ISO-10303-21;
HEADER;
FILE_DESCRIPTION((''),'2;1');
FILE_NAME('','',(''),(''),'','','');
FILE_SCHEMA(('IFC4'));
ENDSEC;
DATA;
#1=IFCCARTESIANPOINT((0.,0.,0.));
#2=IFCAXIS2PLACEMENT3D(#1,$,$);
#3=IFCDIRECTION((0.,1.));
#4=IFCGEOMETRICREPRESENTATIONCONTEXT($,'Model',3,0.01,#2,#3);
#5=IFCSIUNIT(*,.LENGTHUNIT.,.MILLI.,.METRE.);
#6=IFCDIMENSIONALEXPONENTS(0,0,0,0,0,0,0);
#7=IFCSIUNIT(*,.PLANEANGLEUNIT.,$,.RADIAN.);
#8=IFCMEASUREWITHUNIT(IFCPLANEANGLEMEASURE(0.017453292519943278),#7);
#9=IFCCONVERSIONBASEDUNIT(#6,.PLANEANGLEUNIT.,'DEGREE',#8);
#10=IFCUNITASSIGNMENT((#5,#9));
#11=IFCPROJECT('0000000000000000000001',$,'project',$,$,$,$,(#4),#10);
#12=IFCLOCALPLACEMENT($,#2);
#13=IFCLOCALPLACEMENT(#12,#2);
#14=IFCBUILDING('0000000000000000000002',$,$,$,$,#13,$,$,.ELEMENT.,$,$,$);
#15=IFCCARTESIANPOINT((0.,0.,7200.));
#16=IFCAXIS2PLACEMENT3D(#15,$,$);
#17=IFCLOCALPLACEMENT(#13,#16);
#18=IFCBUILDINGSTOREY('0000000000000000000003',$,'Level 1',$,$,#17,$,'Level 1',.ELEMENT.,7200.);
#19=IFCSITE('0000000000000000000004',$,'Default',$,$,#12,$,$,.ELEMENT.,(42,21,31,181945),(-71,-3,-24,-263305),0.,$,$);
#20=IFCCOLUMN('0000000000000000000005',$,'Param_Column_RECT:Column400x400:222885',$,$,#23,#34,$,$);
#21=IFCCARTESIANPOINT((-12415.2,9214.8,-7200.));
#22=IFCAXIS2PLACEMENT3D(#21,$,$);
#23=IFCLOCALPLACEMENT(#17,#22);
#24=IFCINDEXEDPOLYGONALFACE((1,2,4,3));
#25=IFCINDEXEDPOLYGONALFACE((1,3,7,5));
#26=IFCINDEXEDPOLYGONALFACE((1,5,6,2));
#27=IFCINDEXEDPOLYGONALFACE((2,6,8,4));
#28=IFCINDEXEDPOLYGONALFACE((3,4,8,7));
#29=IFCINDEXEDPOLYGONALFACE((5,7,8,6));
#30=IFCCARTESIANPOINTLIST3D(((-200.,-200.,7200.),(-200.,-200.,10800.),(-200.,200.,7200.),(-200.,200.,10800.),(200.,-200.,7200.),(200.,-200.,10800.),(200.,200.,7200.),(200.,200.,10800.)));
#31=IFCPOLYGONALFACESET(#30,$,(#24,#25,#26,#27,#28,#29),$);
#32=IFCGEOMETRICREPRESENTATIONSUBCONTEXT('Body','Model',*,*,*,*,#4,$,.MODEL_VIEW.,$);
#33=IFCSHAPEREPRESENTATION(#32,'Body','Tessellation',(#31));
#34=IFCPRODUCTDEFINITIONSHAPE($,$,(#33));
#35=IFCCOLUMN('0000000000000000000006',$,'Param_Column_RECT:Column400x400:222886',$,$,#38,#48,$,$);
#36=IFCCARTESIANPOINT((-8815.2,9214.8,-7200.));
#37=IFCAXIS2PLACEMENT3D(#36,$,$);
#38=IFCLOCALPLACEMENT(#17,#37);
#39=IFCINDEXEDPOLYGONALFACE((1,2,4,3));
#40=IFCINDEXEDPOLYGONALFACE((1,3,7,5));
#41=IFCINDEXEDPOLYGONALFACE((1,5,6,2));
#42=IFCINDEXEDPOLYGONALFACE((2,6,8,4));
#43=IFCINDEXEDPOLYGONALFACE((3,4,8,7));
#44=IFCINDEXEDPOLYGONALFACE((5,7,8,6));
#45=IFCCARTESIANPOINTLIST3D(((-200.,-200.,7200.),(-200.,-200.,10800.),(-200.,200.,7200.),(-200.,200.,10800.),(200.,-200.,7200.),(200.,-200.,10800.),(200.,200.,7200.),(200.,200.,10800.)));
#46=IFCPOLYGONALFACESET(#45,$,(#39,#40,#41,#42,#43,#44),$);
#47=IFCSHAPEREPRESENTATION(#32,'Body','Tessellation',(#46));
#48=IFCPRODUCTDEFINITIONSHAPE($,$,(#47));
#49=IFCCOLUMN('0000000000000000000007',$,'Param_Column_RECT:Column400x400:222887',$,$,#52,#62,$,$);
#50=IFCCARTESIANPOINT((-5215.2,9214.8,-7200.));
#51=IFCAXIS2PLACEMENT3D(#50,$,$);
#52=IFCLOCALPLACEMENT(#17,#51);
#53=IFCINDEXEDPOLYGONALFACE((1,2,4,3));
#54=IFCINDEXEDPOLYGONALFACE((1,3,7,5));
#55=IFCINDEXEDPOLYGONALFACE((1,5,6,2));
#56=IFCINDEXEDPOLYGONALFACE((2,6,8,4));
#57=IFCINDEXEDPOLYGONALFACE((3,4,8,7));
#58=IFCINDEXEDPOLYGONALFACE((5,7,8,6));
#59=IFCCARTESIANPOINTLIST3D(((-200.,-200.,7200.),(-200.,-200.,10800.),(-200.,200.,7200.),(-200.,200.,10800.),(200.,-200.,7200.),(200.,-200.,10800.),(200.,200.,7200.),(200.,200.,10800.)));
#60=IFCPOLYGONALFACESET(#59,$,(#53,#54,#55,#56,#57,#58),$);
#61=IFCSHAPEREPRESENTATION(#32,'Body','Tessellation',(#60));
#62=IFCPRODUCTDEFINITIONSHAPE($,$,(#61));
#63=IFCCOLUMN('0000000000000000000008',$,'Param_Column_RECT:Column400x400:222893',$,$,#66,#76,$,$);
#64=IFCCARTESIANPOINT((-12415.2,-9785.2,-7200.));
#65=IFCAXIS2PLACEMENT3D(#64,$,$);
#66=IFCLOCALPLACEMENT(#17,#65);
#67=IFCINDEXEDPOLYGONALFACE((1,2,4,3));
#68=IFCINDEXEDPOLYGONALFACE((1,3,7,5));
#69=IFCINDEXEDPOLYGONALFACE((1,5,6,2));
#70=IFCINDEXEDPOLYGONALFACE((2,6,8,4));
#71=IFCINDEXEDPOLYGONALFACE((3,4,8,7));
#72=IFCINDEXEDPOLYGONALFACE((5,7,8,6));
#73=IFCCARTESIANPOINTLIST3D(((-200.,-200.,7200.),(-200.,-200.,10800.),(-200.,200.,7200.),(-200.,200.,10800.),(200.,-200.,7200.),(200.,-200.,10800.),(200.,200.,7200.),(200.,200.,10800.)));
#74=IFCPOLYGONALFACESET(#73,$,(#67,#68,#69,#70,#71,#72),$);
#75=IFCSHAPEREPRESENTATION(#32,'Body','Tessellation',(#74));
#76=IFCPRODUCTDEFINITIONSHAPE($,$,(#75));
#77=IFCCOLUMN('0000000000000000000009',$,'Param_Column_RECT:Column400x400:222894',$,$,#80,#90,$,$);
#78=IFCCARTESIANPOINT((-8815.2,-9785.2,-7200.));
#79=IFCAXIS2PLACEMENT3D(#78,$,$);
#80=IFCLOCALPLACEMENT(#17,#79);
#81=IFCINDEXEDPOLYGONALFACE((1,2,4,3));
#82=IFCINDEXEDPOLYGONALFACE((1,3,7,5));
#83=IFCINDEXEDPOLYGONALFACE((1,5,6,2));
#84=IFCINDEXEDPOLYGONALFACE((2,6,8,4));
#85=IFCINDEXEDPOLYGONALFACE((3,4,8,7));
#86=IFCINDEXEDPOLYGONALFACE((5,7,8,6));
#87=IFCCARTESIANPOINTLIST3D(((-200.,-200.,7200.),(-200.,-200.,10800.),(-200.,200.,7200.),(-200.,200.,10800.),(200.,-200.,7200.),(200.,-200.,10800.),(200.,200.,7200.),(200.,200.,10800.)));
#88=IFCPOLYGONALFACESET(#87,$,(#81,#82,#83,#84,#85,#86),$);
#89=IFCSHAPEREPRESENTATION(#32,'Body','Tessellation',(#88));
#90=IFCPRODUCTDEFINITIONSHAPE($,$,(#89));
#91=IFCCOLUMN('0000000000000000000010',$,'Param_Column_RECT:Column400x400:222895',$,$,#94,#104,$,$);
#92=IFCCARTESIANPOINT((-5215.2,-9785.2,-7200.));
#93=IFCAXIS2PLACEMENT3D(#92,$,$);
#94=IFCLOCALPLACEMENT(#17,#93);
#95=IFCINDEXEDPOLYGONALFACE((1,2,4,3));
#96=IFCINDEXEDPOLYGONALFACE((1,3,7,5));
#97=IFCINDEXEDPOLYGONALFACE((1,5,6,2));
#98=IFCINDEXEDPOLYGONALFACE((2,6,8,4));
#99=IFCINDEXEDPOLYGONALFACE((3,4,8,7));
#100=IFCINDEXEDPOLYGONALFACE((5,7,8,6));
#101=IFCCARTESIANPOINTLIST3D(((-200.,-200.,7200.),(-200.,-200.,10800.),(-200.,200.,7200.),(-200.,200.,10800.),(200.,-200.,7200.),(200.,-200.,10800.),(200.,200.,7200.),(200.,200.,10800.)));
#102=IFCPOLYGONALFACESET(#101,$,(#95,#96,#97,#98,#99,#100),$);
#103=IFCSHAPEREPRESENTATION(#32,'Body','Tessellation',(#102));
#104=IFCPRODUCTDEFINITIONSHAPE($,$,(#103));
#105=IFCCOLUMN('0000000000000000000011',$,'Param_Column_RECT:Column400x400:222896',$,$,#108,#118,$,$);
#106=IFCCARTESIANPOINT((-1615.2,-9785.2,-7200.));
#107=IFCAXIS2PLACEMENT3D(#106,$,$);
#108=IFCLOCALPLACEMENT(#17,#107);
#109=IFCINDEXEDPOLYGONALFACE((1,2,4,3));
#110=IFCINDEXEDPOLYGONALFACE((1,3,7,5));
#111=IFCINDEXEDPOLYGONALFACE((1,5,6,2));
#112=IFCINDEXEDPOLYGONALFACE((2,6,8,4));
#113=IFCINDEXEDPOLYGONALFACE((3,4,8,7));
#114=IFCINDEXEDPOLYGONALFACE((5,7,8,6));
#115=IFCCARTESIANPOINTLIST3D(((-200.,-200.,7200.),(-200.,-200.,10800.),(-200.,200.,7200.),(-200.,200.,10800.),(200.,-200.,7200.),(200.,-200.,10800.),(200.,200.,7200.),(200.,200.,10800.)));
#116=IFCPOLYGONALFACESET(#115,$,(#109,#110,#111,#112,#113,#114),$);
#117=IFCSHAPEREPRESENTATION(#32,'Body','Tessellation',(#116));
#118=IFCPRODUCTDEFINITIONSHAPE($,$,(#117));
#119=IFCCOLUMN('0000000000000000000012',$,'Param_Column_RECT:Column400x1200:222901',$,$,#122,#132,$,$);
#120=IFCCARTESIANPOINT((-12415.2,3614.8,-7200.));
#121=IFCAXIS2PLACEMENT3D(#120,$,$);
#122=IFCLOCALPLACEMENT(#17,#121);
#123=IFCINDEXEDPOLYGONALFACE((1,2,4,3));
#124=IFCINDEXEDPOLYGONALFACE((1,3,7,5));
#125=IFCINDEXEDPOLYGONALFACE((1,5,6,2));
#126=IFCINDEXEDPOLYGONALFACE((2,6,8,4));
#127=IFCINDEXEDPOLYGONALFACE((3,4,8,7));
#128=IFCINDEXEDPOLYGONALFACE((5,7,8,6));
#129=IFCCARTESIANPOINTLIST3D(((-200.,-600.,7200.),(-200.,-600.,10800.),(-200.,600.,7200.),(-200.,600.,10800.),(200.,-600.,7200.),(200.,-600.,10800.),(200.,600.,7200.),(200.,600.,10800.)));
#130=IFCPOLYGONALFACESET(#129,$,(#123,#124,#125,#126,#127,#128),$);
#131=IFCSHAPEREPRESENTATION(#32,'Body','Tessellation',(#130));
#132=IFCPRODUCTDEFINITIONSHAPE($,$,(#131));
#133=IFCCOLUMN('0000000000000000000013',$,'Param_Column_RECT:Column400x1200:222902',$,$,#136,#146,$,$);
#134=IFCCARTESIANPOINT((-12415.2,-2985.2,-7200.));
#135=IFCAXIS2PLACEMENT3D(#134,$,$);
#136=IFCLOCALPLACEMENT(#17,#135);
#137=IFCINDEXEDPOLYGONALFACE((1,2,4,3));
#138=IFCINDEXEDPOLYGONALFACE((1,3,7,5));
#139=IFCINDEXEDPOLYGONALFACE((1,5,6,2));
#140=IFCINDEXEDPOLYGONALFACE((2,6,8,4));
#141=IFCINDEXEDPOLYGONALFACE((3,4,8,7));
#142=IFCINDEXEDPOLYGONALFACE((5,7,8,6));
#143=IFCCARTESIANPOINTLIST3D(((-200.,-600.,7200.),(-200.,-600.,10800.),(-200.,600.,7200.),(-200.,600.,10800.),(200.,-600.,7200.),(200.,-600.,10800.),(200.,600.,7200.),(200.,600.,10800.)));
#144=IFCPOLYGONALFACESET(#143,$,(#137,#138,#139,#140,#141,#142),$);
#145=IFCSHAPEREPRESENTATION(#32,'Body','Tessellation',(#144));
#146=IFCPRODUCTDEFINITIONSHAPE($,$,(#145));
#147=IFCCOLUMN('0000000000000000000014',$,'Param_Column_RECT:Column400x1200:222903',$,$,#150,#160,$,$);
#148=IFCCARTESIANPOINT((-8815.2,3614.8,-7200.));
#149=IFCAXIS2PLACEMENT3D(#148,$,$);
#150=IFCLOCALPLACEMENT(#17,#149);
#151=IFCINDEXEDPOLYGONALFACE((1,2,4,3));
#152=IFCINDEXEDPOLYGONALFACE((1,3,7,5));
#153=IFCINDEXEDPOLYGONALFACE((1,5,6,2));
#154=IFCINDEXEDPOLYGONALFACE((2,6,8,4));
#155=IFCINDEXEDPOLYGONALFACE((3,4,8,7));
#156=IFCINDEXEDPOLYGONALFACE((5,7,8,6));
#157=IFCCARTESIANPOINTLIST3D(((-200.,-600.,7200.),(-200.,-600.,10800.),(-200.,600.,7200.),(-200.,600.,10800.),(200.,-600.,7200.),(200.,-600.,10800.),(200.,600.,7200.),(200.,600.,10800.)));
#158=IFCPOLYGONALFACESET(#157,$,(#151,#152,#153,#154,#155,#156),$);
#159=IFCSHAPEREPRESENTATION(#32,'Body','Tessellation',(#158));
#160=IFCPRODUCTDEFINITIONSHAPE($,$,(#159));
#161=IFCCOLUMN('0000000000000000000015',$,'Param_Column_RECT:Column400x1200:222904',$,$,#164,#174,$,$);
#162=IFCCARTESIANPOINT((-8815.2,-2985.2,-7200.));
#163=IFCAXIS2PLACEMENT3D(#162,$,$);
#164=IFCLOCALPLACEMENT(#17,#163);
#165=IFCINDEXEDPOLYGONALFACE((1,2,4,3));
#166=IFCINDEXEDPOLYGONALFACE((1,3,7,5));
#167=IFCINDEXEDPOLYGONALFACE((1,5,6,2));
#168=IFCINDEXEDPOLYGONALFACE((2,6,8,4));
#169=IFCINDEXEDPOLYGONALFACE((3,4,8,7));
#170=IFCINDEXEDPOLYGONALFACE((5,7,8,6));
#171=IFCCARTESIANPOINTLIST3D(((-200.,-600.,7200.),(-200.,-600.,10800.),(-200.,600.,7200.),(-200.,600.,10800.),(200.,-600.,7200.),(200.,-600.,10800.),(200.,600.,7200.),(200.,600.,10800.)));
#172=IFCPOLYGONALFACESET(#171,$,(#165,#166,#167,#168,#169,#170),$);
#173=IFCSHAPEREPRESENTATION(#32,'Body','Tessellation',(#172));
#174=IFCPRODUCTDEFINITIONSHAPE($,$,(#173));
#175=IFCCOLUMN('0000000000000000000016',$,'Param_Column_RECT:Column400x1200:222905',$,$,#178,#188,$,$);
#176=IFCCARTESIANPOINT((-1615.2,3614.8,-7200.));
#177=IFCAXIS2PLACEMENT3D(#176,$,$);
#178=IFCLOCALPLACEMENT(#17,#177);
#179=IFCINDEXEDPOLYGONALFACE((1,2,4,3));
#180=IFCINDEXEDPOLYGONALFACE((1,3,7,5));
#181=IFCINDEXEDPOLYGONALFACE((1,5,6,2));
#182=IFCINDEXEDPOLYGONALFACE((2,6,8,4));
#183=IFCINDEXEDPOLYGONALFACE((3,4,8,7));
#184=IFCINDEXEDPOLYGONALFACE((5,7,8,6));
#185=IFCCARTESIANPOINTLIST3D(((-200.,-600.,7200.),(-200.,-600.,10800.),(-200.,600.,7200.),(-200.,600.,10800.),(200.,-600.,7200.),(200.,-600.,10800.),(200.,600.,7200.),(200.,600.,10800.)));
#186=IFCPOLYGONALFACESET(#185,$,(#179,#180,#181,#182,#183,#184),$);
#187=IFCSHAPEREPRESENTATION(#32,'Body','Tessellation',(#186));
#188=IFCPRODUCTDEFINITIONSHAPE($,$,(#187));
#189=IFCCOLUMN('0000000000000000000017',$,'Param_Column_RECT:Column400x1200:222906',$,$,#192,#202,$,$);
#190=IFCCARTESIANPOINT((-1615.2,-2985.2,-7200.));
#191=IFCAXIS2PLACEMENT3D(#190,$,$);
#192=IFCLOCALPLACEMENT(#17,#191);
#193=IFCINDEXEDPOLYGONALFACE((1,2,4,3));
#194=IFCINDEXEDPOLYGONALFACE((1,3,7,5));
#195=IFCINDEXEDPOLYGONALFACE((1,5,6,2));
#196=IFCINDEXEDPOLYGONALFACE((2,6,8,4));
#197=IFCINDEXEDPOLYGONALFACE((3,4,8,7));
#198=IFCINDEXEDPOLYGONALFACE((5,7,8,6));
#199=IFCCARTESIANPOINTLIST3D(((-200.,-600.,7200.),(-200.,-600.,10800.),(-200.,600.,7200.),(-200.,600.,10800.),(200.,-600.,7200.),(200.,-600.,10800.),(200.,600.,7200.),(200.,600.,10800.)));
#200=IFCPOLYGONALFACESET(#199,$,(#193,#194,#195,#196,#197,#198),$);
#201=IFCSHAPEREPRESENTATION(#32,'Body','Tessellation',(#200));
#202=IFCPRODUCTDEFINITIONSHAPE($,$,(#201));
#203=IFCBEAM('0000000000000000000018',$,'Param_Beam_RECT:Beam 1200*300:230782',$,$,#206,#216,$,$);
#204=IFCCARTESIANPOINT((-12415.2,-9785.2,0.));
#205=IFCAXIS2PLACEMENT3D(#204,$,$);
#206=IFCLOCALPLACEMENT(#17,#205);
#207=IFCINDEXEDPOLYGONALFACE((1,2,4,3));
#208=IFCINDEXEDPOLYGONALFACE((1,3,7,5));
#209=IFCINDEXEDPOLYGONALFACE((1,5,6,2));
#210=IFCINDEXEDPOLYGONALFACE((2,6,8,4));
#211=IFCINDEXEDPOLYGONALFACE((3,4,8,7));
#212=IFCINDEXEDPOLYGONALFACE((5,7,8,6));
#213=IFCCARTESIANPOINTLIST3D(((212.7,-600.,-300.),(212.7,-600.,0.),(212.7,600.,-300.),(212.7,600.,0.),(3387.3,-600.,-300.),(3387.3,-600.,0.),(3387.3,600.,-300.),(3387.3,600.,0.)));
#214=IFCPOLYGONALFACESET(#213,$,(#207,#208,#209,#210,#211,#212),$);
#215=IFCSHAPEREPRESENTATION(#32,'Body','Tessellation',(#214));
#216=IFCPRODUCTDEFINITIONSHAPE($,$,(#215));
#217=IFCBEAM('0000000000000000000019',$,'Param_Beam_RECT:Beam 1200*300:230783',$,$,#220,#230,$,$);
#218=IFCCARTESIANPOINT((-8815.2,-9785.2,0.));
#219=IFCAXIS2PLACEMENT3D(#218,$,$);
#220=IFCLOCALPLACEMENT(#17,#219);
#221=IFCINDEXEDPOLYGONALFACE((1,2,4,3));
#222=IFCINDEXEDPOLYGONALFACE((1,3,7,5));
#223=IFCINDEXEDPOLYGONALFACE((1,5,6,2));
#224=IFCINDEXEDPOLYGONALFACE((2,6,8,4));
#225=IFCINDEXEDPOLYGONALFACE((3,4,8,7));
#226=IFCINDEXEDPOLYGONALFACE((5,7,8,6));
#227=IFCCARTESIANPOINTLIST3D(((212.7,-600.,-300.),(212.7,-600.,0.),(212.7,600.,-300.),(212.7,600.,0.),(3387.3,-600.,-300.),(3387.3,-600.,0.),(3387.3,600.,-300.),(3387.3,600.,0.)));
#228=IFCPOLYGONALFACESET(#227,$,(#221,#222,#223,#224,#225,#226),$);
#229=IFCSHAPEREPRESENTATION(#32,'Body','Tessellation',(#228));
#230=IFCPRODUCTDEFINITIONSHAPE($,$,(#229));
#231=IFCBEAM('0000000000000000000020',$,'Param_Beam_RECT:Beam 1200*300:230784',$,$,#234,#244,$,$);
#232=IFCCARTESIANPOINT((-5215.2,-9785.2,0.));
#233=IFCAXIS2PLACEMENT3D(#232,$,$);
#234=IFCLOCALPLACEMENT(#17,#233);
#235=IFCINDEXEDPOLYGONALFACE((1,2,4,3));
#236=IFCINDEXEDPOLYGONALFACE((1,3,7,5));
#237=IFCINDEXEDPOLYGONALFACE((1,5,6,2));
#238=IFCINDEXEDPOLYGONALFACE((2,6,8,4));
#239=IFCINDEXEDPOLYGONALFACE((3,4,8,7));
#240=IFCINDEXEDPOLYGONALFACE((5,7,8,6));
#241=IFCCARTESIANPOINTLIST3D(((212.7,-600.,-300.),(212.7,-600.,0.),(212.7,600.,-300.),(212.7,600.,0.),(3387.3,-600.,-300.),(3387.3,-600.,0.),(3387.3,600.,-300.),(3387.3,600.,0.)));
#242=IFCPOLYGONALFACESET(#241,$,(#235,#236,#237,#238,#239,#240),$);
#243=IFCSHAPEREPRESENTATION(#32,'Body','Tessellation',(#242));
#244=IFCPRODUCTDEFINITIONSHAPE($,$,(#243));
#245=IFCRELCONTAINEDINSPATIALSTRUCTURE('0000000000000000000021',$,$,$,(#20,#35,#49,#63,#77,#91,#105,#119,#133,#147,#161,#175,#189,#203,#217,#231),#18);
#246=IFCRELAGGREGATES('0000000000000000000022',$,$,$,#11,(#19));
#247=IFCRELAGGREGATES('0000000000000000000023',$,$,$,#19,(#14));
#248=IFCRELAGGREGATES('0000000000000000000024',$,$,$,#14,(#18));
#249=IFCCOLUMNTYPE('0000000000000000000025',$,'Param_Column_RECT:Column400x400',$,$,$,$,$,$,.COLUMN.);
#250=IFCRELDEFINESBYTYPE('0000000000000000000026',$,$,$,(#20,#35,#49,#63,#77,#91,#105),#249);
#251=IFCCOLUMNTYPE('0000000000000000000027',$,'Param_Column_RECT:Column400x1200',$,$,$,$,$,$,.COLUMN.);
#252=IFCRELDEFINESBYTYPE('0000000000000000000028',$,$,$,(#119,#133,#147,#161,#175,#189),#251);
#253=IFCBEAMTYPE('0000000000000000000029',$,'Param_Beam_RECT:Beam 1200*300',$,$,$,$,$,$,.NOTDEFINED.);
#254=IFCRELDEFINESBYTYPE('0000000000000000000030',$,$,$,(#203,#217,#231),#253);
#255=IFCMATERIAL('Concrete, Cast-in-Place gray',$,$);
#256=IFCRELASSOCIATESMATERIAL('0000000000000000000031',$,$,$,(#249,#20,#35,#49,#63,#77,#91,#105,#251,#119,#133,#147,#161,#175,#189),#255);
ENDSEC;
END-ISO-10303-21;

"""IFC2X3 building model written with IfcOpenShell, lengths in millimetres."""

from ifc_helpers import new_model, entity, si_unit, converted_unit, direction, frame, frame_2d, origin, origin_2d_with_axis, place, context, subcontext, project, spatial, rectangle, extrude, source, transform, mapped, material, type_object, type_shapes, element, save


model = new_model("IFC2X3")

# Units and contexts
model_context = context("Model", 3, precision=0.01, world=origin(), true_north=direction((0.0, 1.0)))
body_context = subcontext(model_context, "Body", "Model", "MODEL_VIEW")
ifc_project = project(units=[si_unit("LENGTHUNIT", "METRE", prefix="MILLI"), converted_unit("PLANEANGLEUNIT", "DEGREE", entity("IfcPlaneAngleMeasure", 0.017453292519943278), si_unit("PLANEANGLEUNIT", "RADIAN"), dimensions=[0, 0, 0, 0, 0, 0, 0])], contexts=[model_context])

# Site, building, storey
site_placement = place(None, origin())
site = spatial("IfcSite", under=ifc_project, at=site_placement, Name="Default", CompositionType="ELEMENT", RefLatitude=(42, 21, 31, 181945), RefLongitude=(-71, -3, -24, -263305), RefElevation=0.0)
building_placement = place(site_placement, origin())
building = spatial("IfcBuilding", under=site, at=building_placement, CompositionType="ELEMENT")
storey_placement = place(building_placement, frame((0.0, 0.0, 7200.0)))
storey = spatial("IfcBuildingStorey", under=building, at=storey_placement, Name="Level 1", LongName="Level 1", CompositionType="ELEMENT", Elevation=7200.0)

# Columns
ifc_material_1 = material(Name="Concrete, Cast-in-Place gray")
column_type_1 = type_object("IfcColumnType", Name="Param_Column_RECT:Column400x400", PredefinedType="COLUMN", material=ifc_material_1)
shared_shape_1 = source(origin(), body_context, "Body", "SweptSolid", [
    extrude(rectangle(XDim=400.0, YDim=400.0, at=origin_2d_with_axis()), frame((0.0, 0.0, 7200.0), z_axis=(0.0, 0.0, 1.0), x_axis=(-1.0, 0.0, 0.0)), (0.0, 0.0, 1.0), 3600.0),
])
type_shapes(column_type_1, [shared_shape_1])
for number, where, name in (
    (1, (-12415.2, 9214.8, -7200.0), "Param_Column_RECT:Column400x400:222885"),
    (2, (-8815.2, 9214.8, -7200.0), "Param_Column_RECT:Column400x400:222886"),
    (3, (-5215.2, 9214.8, -7200.0), "Param_Column_RECT:Column400x400:222887"),
    (4, (-12415.2, -9785.2, -7200.0), "Param_Column_RECT:Column400x400:222893"),
    (5, (-8815.2, -9785.2, -7200.0), "Param_Column_RECT:Column400x400:222894"),
    (6, (-5215.2, -9785.2, -7200.0), "Param_Column_RECT:Column400x400:222895"),
    (7, (-1615.2, -9785.2, -7200.0), "Param_Column_RECT:Column400x400:222896"),
):
    element("IfcColumn", number, at=place(storey_placement, frame(where)), inside=storey, type_object=column_type_1, material=ifc_material_1, Name=name, context=body_context, shape_type="MappedRepresentation", body=[
        mapped(shared_shape_1, transform((0.0, 0.0, 0.0), scale=1.0)),
    ])
column_type_2 = type_object("IfcColumnType", Name="Param_Column_RECT:Column400x1200", PredefinedType="COLUMN", material=ifc_material_1)
shared_shape_2 = source(origin(), body_context, "Body", "SweptSolid", [
    extrude(rectangle(XDim=400.0, YDim=1200.0, at=origin_2d_with_axis()), frame((0.0, 0.0, 7200.0), z_axis=(0.0, 0.0, 1.0), x_axis=(-1.0, 0.0, 0.0)), (0.0, 0.0, 1.0), 3600.0),
])
type_shapes(column_type_2, [shared_shape_2])
for number, where, name in (
    (8, (-12415.2, 3614.8, -7200.0), "Param_Column_RECT:Column400x1200:222901"),
    (9, (-12415.2, -2985.2, -7200.0), "Param_Column_RECT:Column400x1200:222902"),
    (10, (-8815.2, 3614.8, -7200.0), "Param_Column_RECT:Column400x1200:222903"),
    (11, (-8815.2, -2985.2, -7200.0), "Param_Column_RECT:Column400x1200:222904"),
    (12, (-1615.2, 3614.8, -7200.0), "Param_Column_RECT:Column400x1200:222905"),
    (13, (-1615.2, -2985.2, -7200.0), "Param_Column_RECT:Column400x1200:222906"),
):
    element("IfcColumn", number, at=place(storey_placement, frame(where)), inside=storey, type_object=column_type_2, material=ifc_material_1, Name=name, context=body_context, shape_type="MappedRepresentation", body=[
        mapped(shared_shape_2, transform((0.0, 0.0, 0.0), scale=1.0)),
    ])

# Beams
beam_type_1 = type_object("IfcBeamType", Name="Param_Beam_RECT:Beam 1200*300", PredefinedType="NOTDEFINED")
beam_1_placement = place(storey_placement, frame((-12415.2, -9785.2, 0.0)))
element("IfcBeam", 14, at=beam_1_placement, inside=storey, type_object=beam_type_1, Name="Param_Beam_RECT:Beam 1200*300:230782", context=body_context, shape_type="SweptSolid", body=[
    extrude(rectangle(XDim=300.0, YDim=1200.0, at=frame_2d((0.0, 0.0), x_axis=(1.0, 0.0))), frame((212.7, 0.0, -150.0), z_axis=(1.0, 0.0, 0.0), x_axis=(0.0, 0.0, -1.0)), (0.0, 0.0, 1.0), 3174.6),
])
beam_2_placement = place(storey_placement, frame((-8815.2, -9785.2, 0.0)))
element("IfcBeam", 15, at=beam_2_placement, inside=storey, type_object=beam_type_1, Name="Param_Beam_RECT:Beam 1200*300:230783", context=body_context, shape_type="SweptSolid", body=[
    extrude(rectangle(XDim=300.0, YDim=1200.0, at=frame_2d((0.0, 0.0), x_axis=(1.0, 0.0))), frame((212.7, 0.0, -150.0), z_axis=(1.0, 0.0, 0.0), x_axis=(0.0, 0.0, -1.0)), (0.0, 0.0, 1.0), 3174.6),
])
beam_3_placement = place(storey_placement, frame((-5215.2, -9785.2, 0.0)))
element("IfcBeam", 16, at=beam_3_placement, inside=storey, type_object=beam_type_1, Name="Param_Beam_RECT:Beam 1200*300:230784", context=body_context, shape_type="SweptSolid", body=[
    extrude(rectangle(XDim=300.0, YDim=1200.0, at=frame_2d((0.0, 0.0), x_axis=(1.0, 0.0))), frame((212.7, 0.0, -150.0), z_axis=(1.0, 0.0, 0.0), x_axis=(0.0, 0.0, -1.0)), (0.0, 0.0, 1.0), 3174.6),
])

save(model, "model.ifc")
